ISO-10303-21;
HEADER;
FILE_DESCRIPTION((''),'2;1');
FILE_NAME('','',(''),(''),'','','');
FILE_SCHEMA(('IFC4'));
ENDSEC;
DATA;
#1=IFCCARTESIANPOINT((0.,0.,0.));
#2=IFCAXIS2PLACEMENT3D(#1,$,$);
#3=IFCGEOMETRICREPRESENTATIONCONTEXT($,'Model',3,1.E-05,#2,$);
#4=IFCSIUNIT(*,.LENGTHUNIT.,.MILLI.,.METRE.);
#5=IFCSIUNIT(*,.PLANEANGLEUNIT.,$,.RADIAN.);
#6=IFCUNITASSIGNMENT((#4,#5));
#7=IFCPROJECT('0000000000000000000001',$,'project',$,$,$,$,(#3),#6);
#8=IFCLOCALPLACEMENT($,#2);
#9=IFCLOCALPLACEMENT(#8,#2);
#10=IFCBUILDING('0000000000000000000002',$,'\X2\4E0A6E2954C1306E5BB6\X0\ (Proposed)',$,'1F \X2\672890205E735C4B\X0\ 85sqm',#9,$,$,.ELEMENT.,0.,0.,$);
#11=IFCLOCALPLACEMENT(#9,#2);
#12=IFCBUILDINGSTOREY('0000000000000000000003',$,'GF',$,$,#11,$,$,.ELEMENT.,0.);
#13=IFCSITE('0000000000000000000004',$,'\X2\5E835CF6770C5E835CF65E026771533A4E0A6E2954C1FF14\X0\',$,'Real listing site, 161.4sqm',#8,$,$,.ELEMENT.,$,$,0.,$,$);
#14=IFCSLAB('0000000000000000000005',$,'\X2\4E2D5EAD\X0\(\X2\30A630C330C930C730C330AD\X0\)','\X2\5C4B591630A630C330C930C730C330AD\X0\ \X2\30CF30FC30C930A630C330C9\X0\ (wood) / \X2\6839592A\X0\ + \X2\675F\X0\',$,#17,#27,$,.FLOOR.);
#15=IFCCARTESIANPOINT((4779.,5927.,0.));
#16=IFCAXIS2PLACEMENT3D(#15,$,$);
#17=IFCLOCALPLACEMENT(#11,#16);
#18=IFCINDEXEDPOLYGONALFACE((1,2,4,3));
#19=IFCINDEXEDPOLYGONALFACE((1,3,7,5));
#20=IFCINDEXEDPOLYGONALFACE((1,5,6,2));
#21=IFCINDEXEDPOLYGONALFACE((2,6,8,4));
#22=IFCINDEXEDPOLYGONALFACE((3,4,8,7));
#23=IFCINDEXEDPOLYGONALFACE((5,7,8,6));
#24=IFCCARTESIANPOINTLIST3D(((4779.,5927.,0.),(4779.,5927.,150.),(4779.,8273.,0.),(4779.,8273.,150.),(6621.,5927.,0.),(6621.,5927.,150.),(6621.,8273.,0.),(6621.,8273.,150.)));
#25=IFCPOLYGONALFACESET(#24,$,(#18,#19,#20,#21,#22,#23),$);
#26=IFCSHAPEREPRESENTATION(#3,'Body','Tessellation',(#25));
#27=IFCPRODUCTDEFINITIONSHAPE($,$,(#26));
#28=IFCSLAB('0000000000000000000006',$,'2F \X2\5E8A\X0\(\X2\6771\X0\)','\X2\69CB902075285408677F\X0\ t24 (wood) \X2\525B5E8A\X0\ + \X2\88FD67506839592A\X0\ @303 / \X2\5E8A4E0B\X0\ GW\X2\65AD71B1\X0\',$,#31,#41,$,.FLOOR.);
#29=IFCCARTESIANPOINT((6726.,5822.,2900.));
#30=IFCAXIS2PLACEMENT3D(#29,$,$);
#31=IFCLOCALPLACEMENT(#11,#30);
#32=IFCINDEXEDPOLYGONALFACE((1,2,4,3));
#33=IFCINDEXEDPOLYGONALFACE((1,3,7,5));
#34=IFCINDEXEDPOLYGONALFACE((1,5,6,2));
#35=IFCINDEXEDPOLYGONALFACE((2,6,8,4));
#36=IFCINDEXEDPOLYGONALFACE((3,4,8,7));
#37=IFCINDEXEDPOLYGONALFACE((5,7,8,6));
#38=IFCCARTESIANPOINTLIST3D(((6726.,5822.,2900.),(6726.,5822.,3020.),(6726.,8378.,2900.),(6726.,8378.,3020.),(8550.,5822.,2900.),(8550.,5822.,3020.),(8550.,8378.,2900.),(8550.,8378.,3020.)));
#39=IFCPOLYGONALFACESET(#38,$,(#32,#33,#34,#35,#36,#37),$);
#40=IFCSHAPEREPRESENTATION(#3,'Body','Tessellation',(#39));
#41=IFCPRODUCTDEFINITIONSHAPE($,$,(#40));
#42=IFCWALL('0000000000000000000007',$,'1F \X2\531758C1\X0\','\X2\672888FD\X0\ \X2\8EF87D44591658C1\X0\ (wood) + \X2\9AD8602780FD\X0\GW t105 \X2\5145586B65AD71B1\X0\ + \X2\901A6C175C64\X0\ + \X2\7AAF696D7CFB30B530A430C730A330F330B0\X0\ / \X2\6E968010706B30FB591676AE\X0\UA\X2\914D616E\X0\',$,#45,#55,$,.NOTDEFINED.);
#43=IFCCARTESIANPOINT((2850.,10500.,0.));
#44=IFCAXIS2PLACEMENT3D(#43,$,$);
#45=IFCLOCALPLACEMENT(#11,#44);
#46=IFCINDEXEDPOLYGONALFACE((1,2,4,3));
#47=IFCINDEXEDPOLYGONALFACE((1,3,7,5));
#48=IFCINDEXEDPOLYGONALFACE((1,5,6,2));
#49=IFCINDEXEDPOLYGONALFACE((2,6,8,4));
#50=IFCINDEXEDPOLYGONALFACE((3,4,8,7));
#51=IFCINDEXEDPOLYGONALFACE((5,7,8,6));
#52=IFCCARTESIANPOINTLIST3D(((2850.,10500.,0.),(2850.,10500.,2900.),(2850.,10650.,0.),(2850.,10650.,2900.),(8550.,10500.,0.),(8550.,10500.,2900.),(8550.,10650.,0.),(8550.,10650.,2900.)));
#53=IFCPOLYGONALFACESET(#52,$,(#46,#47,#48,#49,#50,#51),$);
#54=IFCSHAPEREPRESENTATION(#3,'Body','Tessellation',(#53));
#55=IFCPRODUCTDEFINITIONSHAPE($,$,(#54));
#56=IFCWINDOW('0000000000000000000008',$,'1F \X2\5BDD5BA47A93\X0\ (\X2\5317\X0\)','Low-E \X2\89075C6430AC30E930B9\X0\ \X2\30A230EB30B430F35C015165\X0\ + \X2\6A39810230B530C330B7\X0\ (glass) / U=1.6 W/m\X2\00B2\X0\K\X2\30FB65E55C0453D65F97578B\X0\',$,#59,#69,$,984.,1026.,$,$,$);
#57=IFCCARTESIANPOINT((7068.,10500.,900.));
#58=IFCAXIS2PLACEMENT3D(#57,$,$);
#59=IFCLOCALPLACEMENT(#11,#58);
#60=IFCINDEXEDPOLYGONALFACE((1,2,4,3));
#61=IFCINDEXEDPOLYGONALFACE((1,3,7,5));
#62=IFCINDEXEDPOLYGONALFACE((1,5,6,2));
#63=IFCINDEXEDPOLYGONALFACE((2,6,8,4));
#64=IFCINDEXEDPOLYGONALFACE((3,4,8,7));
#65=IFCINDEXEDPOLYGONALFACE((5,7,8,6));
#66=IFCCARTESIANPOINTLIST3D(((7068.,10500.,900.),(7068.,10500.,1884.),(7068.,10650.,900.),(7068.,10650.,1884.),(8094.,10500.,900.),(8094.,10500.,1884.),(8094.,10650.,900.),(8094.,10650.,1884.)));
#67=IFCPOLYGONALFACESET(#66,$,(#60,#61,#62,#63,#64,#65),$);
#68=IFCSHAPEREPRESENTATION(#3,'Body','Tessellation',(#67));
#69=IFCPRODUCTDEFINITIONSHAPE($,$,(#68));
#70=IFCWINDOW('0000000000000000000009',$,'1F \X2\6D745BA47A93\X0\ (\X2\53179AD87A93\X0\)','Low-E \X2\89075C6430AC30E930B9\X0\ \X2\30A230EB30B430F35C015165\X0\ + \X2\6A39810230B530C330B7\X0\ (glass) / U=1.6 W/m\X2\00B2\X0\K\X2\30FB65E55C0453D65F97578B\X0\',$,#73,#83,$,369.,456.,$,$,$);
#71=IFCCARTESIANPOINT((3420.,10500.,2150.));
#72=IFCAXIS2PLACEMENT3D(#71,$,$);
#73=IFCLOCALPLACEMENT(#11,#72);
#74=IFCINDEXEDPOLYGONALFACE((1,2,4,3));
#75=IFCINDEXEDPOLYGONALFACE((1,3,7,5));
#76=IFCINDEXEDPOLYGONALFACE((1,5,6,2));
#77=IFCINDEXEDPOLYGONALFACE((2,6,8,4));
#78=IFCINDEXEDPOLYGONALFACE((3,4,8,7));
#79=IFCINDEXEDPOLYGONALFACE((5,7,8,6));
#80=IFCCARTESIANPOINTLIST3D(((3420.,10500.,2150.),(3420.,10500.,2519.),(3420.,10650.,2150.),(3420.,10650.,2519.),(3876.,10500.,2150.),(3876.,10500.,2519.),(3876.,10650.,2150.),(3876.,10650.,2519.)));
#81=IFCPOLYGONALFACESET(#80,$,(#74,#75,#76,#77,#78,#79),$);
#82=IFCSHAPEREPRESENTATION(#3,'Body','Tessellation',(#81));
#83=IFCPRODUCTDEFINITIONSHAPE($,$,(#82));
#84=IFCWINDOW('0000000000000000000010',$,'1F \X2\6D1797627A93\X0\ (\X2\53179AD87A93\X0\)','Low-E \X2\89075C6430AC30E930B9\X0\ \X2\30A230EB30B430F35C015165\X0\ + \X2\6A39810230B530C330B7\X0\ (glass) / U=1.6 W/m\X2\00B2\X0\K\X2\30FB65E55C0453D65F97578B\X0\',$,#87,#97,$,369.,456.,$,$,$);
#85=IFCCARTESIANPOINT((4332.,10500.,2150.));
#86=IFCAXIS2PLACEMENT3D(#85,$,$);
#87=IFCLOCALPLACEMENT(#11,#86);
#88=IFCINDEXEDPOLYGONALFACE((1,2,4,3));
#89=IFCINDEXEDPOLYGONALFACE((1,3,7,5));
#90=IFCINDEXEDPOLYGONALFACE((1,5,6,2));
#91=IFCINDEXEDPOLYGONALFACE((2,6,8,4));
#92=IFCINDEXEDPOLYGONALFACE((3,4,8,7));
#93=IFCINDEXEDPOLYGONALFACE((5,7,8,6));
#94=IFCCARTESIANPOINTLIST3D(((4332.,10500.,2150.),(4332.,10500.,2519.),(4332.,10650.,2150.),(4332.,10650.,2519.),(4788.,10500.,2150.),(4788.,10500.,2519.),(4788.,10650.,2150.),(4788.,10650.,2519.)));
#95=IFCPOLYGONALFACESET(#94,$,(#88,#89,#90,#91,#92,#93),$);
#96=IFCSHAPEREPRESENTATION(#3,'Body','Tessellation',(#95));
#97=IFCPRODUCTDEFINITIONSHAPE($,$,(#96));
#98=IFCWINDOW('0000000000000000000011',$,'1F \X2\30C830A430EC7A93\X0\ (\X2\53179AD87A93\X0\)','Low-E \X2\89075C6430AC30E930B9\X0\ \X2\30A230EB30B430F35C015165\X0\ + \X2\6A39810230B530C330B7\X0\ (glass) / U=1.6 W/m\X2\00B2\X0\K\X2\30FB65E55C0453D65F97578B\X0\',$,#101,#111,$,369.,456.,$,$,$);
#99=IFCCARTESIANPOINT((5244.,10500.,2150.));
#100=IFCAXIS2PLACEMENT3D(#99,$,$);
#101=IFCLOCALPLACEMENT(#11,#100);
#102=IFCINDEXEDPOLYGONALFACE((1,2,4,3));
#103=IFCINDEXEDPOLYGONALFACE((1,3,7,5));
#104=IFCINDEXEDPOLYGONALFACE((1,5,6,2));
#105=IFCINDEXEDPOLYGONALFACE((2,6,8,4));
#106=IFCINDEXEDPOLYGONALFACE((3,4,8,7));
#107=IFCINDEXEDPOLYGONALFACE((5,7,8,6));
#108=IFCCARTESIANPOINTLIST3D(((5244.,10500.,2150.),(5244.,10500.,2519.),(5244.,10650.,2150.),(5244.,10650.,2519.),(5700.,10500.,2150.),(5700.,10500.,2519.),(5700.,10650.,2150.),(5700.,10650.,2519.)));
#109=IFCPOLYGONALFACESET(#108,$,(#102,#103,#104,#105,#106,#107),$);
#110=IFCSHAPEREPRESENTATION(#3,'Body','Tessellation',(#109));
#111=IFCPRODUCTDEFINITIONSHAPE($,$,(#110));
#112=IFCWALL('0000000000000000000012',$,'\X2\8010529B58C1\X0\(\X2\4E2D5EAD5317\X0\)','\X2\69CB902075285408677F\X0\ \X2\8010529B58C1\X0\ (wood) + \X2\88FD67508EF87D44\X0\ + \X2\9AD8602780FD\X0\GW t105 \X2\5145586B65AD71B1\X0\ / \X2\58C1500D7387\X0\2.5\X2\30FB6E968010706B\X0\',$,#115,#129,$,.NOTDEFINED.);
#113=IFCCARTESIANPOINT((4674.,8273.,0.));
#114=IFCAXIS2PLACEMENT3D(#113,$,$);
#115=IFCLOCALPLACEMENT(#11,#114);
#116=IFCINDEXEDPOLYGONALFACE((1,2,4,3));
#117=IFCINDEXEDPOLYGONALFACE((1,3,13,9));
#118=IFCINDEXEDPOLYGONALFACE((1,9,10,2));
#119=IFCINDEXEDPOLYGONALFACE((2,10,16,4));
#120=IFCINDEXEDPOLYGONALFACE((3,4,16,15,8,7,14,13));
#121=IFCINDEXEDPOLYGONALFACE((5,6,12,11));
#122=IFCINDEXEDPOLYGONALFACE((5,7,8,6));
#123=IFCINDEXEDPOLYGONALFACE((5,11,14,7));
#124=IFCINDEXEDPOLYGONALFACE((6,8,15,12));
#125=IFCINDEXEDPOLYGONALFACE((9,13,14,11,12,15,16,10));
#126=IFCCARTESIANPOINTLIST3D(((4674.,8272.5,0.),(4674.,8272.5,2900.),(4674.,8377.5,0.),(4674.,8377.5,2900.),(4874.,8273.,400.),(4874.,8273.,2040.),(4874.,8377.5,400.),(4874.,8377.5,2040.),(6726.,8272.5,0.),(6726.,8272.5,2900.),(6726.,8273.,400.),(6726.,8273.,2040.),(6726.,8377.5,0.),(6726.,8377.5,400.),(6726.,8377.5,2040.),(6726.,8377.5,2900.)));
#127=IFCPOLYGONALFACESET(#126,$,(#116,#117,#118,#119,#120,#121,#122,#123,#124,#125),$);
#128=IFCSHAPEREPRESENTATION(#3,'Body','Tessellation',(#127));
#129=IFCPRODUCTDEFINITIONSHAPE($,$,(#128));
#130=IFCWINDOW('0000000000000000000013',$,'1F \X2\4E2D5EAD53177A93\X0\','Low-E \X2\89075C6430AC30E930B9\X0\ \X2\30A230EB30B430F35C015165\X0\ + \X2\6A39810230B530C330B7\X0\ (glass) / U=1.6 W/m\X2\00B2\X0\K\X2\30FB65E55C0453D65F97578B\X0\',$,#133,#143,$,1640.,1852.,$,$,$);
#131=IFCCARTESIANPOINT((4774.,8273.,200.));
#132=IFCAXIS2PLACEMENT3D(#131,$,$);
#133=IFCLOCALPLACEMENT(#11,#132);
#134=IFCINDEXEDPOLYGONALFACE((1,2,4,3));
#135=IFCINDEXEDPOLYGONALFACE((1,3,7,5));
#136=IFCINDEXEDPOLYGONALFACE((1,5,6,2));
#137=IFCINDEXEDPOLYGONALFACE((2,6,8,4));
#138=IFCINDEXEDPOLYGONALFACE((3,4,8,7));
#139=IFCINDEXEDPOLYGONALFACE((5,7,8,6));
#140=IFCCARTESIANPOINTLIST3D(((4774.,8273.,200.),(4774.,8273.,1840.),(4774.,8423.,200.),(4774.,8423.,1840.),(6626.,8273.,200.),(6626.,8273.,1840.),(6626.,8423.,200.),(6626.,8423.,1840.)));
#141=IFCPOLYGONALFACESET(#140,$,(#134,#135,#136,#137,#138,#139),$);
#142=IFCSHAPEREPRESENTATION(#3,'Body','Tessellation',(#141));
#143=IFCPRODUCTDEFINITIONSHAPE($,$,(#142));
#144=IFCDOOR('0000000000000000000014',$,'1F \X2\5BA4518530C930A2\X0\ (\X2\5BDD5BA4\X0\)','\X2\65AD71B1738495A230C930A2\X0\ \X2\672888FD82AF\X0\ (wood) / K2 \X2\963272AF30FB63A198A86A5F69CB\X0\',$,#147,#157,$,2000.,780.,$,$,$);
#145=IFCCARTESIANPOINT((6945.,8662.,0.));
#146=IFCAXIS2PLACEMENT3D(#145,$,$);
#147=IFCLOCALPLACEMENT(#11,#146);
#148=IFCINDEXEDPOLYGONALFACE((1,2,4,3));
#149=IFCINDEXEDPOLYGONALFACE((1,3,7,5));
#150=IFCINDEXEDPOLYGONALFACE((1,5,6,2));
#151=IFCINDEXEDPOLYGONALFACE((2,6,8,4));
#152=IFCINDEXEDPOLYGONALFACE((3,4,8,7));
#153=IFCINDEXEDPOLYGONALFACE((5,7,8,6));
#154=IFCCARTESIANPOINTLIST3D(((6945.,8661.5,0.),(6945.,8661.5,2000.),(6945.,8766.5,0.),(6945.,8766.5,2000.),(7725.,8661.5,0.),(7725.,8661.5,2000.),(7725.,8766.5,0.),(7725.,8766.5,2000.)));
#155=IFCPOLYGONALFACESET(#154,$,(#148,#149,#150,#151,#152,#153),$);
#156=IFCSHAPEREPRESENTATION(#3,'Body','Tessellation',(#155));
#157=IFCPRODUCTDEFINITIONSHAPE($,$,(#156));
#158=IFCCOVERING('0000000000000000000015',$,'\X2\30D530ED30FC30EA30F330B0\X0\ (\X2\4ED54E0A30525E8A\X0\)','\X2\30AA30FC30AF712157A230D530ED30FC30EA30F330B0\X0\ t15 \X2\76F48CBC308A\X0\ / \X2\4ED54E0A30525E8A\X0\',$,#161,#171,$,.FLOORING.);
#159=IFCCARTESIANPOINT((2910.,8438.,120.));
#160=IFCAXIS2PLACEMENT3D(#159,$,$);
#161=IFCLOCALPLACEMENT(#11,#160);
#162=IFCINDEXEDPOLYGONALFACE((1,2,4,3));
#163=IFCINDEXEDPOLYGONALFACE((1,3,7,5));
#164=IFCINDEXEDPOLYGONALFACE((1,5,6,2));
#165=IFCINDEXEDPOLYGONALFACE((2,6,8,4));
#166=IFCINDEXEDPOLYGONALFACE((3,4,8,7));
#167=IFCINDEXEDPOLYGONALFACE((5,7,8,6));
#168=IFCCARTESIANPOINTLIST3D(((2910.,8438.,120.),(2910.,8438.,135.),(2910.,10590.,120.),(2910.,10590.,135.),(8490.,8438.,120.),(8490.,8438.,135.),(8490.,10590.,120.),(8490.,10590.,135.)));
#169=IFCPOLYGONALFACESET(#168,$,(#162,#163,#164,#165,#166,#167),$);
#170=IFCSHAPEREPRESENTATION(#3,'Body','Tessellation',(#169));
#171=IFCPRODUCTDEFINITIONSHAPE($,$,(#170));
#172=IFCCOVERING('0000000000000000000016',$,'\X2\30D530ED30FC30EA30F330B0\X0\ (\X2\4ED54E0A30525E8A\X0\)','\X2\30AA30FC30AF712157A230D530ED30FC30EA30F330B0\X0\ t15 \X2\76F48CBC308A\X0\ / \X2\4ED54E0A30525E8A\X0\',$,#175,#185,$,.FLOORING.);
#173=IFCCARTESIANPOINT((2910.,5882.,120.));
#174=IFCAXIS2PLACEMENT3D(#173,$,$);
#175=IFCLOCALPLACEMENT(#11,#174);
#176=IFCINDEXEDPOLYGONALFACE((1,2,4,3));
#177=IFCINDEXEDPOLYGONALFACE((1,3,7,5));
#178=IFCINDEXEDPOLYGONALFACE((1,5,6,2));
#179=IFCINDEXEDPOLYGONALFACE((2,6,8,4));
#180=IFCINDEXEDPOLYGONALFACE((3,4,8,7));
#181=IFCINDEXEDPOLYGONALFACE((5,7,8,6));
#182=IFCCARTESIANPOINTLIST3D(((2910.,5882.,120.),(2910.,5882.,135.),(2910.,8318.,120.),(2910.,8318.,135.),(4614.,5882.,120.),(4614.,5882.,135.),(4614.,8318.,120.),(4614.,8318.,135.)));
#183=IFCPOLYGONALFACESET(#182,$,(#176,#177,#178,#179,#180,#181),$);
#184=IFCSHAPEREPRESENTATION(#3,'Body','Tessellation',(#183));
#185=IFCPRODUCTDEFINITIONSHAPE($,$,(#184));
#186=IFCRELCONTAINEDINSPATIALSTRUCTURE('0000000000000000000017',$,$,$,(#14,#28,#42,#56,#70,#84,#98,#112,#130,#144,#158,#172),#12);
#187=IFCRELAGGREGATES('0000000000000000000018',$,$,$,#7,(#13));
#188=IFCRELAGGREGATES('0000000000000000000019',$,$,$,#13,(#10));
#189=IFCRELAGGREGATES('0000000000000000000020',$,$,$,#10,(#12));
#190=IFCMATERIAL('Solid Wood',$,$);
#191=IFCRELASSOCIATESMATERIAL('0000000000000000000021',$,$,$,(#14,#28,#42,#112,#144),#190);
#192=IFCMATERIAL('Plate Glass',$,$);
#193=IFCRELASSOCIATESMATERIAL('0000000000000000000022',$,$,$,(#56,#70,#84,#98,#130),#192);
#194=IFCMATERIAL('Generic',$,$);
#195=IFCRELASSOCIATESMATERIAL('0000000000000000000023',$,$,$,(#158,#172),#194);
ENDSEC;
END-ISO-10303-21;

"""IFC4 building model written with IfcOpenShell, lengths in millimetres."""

from ifc_helpers import new_model, si_unit, frame, frame_2d, origin, place, context, project, spatial, rectangle, extrude, material, element, fill, save


model = new_model("IFC4")

# Units and contexts
model_context = context("Model", 3, precision=1e-05, world=origin())
ifc_project = project(units=[si_unit("LENGTHUNIT", "METRE", prefix="MILLI"), si_unit("PLANEANGLEUNIT", "RADIAN")], contexts=[model_context])

# Site, building, storey
site_placement = place(None, origin())
site = spatial("IfcSite", under=ifc_project, at=site_placement, Name="広島県広島市東区上温品４", ObjectType="Real listing site, 161.4sqm", CompositionType="ELEMENT", RefElevation=0.0)
building_placement = place(site_placement, origin())
building = spatial("IfcBuilding", under=site, at=building_placement, Name="上温品の家 (Proposed)", ObjectType="1F 木造平屋 85sqm", CompositionType="ELEMENT", ElevationOfRefHeight=0.0, ElevationOfTerrain=0.0)
storey_placement = place(building_placement, origin())
storey = spatial("IfcBuildingStorey", under=building, at=storey_placement, Name="GF", CompositionType="ELEMENT", Elevation=0.0)

# Slabs
ifc_material_1 = material(Name="Solid Wood")
slab_1_placement = place(storey_placement, frame((4779.0, 5927.0, 0.0)))
element("IfcSlab", 1, at=slab_1_placement, inside=storey, material=ifc_material_1, Name="中庭(ウッドデッキ)", Description="屋外ウッドデッキ ハードウッド (wood) / 根太 + 束", PredefinedType="FLOOR", context=model_context, shape_type="SweptSolid", body=[
    extrude(rectangle(XDim=1842.0, YDim=2346.0, at=frame_2d((921.0, 1173.0))), frame((4779.0, 5927.0, 0.0)), (0.0, 0.0, 1.0), 150.0),
])
slab_2_placement = place(storey_placement, frame((6726.0, 5822.0, 2900.0)))
element("IfcSlab", 2, at=slab_2_placement, inside=storey, material=ifc_material_1, Name="2F 床(東)", Description="構造用合板 t24 (wood) 剛床 + 製材根太 @303 / 床下 GW断熱", PredefinedType="FLOOR", context=model_context, shape_type="SweptSolid", body=[
    extrude(rectangle(XDim=1824.0, YDim=2556.0, at=frame_2d((912.0, 1278.0))), frame((6726.0, 5822.0, 2900.0)), (0.0, 0.0, 1.0), 120.0),
])

# Wall, openings, windows
wall_1_placement = place(storey_placement, frame((2850.0, 10500.0, 0.0)))
wall_1 = element("IfcWall", 3, at=wall_1_placement, inside=storey, material=ifc_material_1, Name="1F 北壁", Description="木製 軸組外壁 (wood) + 高性能GW t105 充填断熱 + 通気層 + 窯業系サイディング / 準耐火・外皮UA配慮", PredefinedType="NOTDEFINED", context=model_context, shape_type="SweptSolid", body=[
    extrude(rectangle(XDim=5700.0, YDim=150.0, at=frame_2d((2850.0, 75.0))), frame((2850.0, 10500.0, 0.0)), (0.0, 0.0, 1.0), 2900.0),
])
opening_1_placement = place(storey_placement, frame((7068.0, 10500.0, 900.0)))
opening_1 = element("IfcOpeningElement", 4, at=opening_1_placement, cuts=wall_1, PredefinedType="NOTDEFINED", context=model_context, shape_type="SweptSolid", body=[
    extrude(rectangle(XDim=1026.0, YDim=150.0, at=frame_2d((513.0, 75.0))), frame((7068.0, 10500.0, 900.0)), (0.0, 0.0, 1.0), 984.0),
])
opening_2_placement = place(storey_placement, frame((3420.0, 10500.0, 2150.0)))
opening_2 = element("IfcOpeningElement", 5, at=opening_2_placement, cuts=wall_1, PredefinedType="NOTDEFINED", context=model_context, shape_type="SweptSolid", body=[
    extrude(rectangle(XDim=456.0, YDim=150.0, at=frame_2d((228.0, 75.0))), frame((3420.0, 10500.0, 2150.0)), (0.0, 0.0, 1.0), 369.0),
])
opening_3_placement = place(storey_placement, frame((4332.0, 10500.0, 2150.0)))
opening_3 = element("IfcOpeningElement", 6, at=opening_3_placement, cuts=wall_1, PredefinedType="NOTDEFINED", context=model_context, shape_type="SweptSolid", body=[
    extrude(rectangle(XDim=456.0, YDim=150.0, at=frame_2d((228.0, 75.0))), frame((4332.0, 10500.0, 2150.0)), (0.0, 0.0, 1.0), 369.0),
])
opening_4_placement = place(storey_placement, frame((5244.0, 10500.0, 2150.0)))
opening_4 = element("IfcOpeningElement", 7, at=opening_4_placement, cuts=wall_1, PredefinedType="NOTDEFINED", context=model_context, shape_type="SweptSolid", body=[
    extrude(rectangle(XDim=456.0, YDim=150.0, at=frame_2d((228.0, 75.0))), frame((5244.0, 10500.0, 2150.0)), (0.0, 0.0, 1.0), 369.0),
])
ifc_material_2 = material(Name="Plate Glass")
window_1_placement = place(storey_placement, frame((7068.0, 10500.0, 900.0)))
window_1 = element("IfcWindow", 8, at=window_1_placement, inside=storey, material=ifc_material_2, Name="1F 寝室窓 (北)", Description="Low-E 複層ガラス アルゴン封入 + 樹脂サッシ (glass) / U=1.6 W/m²K・日射取得型", OverallHeight=984.0, OverallWidth=1026.0, context=model_context, shape_type="SweptSolid", body=[
    extrude(rectangle(XDim=1026.0, YDim=150.0, at=frame_2d((513.0, 75.0))), frame((7068.0, 10500.0, 900.0)), (0.0, 0.0, 1.0), 984.0),
])
fill(opening_1, window_1)
window_2_placement = place(storey_placement, frame((3420.0, 10500.0, 2150.0)))
window_2 = element("IfcWindow", 9, at=window_2_placement, inside=storey, material=ifc_material_2, Name="1F 浴室窓 (北高窓)", Description="Low-E 複層ガラス アルゴン封入 + 樹脂サッシ (glass) / U=1.6 W/m²K・日射取得型", OverallHeight=369.0, OverallWidth=456.0, context=model_context, shape_type="SweptSolid", body=[
    extrude(rectangle(XDim=456.0, YDim=150.0, at=frame_2d((228.0, 75.0))), frame((3420.0, 10500.0, 2150.0)), (0.0, 0.0, 1.0), 369.0),
])
fill(opening_2, window_2)
window_3_placement = place(storey_placement, frame((4332.0, 10500.0, 2150.0)))
window_3 = element("IfcWindow", 10, at=window_3_placement, inside=storey, material=ifc_material_2, Name="1F 洗面窓 (北高窓)", Description="Low-E 複層ガラス アルゴン封入 + 樹脂サッシ (glass) / U=1.6 W/m²K・日射取得型", OverallHeight=369.0, OverallWidth=456.0, context=model_context, shape_type="SweptSolid", body=[
    extrude(rectangle(XDim=456.0, YDim=150.0, at=frame_2d((228.0, 75.0))), frame((4332.0, 10500.0, 2150.0)), (0.0, 0.0, 1.0), 369.0),
])
fill(opening_3, window_3)
window_4_placement = place(storey_placement, frame((5244.0, 10500.0, 2150.0)))
window_4 = element("IfcWindow", 11, at=window_4_placement, inside=storey, material=ifc_material_2, Name="1F トイレ窓 (北高窓)", Description="Low-E 複層ガラス アルゴン封入 + 樹脂サッシ (glass) / U=1.6 W/m²K・日射取得型", OverallHeight=369.0, OverallWidth=456.0, context=model_context, shape_type="SweptSolid", body=[
    extrude(rectangle(XDim=456.0, YDim=150.0, at=frame_2d((228.0, 75.0))), frame((5244.0, 10500.0, 2150.0)), (0.0, 0.0, 1.0), 369.0),
])
fill(opening_4, window_4)

# Wall, opening, window
wall_2_placement = place(storey_placement, frame((4674.0, 8273.0, 0.0)))
wall_2 = element("IfcWall", 12, at=wall_2_placement, inside=storey, material=ifc_material_1, Name="耐力壁(中庭北)", Description="構造用合板 耐力壁 (wood) + 製材軸組 + 高性能GW t105 充填断熱 / 壁倍率2.5・準耐火", PredefinedType="NOTDEFINED", context=model_context, shape_type="SweptSolid", body=[
    extrude(rectangle(XDim=2052.0, YDim=105.0, at=frame_2d((1026.0, 52.0))), frame((4674.0, 8273.0, 0.0)), (0.0, 0.0, 1.0), 2900.0),
])
opening_5_placement = place(storey_placement, frame((4774.0, 8273.0, 200.0)))
opening_5 = element("IfcOpeningElement", 13, at=opening_5_placement, cuts=wall_2, PredefinedType="NOTDEFINED", context=model_context, shape_type="SweptSolid", body=[
    extrude(rectangle(XDim=1852.0, YDim=150.0, at=frame_2d((926.0, 75.0))), frame((4774.0, 8273.0, 200.0)), (0.0, 0.0, 1.0), 1640.0),
])
window_5_placement = place(storey_placement, frame((4774.0, 8273.0, 200.0)))
window_5 = element("IfcWindow", 14, at=window_5_placement, inside=storey, material=ifc_material_2, Name="1F 中庭北窓", Description="Low-E 複層ガラス アルゴン封入 + 樹脂サッシ (glass) / U=1.6 W/m²K・日射取得型", OverallHeight=1640.0, OverallWidth=1852.0, context=model_context, shape_type="SweptSolid", body=[
    extrude(rectangle(XDim=1852.0, YDim=150.0, at=frame_2d((926.0, 75.0))), frame((4774.0, 8273.0, 200.0)), (0.0, 0.0, 1.0), 1640.0),
])
fill(opening_5, window_5)

# Door
door_1_placement = place(storey_placement, frame((6945.0, 8662.0, 0.0)))
element("IfcDoor", 15, at=door_1_placement, inside=storey, material=ifc_material_1, Name="1F 室内ドア (寝室)", Description="断熱玄関ドア 木製芯 (wood) / K2 防犯・採風機構", OverallHeight=2000.0, OverallWidth=780.0, context=model_context, shape_type="SweptSolid", body=[
    extrude(rectangle(XDim=780.0, YDim=105.0, at=frame_2d((390.0, 52.0))), frame((6945.0, 8662.0, 0.0)), (0.0, 0.0, 1.0), 2000.0),
])

# Coverings
ifc_material_3 = material(Name="Generic")
covering_1_placement = place(storey_placement, frame((2910.0, 8438.0, 120.0)))
element("IfcCovering", 16, at=covering_1_placement, inside=storey, material=ifc_material_3, Name="フローリング (仕上げ床)", Description="オーク無垢フローリング t15 直貼り / 仕上げ床", PredefinedType="FLOORING", context=model_context, shape_type="SweptSolid", body=[
    extrude(rectangle(XDim=5580.0, YDim=2152.0, at=frame_2d((2790.0, 1076.0))), frame((2910.0, 8438.0, 120.0)), (0.0, 0.0, 1.0), 15.0),
])
covering_2_placement = place(storey_placement, frame((2910.0, 5882.0, 120.0)))
element("IfcCovering", 17, at=covering_2_placement, inside=storey, material=ifc_material_3, Name="フローリング (仕上げ床)", Description="オーク無垢フローリング t15 直貼り / 仕上げ床", PredefinedType="FLOORING", context=model_context, shape_type="SweptSolid", body=[
    extrude(rectangle(XDim=1704.0, YDim=2436.0, at=frame_2d((852.0, 1218.0))), frame((2910.0, 5882.0, 120.0)), (0.0, 0.0, 1.0), 15.0),
])

save(model, "model.ifc")
